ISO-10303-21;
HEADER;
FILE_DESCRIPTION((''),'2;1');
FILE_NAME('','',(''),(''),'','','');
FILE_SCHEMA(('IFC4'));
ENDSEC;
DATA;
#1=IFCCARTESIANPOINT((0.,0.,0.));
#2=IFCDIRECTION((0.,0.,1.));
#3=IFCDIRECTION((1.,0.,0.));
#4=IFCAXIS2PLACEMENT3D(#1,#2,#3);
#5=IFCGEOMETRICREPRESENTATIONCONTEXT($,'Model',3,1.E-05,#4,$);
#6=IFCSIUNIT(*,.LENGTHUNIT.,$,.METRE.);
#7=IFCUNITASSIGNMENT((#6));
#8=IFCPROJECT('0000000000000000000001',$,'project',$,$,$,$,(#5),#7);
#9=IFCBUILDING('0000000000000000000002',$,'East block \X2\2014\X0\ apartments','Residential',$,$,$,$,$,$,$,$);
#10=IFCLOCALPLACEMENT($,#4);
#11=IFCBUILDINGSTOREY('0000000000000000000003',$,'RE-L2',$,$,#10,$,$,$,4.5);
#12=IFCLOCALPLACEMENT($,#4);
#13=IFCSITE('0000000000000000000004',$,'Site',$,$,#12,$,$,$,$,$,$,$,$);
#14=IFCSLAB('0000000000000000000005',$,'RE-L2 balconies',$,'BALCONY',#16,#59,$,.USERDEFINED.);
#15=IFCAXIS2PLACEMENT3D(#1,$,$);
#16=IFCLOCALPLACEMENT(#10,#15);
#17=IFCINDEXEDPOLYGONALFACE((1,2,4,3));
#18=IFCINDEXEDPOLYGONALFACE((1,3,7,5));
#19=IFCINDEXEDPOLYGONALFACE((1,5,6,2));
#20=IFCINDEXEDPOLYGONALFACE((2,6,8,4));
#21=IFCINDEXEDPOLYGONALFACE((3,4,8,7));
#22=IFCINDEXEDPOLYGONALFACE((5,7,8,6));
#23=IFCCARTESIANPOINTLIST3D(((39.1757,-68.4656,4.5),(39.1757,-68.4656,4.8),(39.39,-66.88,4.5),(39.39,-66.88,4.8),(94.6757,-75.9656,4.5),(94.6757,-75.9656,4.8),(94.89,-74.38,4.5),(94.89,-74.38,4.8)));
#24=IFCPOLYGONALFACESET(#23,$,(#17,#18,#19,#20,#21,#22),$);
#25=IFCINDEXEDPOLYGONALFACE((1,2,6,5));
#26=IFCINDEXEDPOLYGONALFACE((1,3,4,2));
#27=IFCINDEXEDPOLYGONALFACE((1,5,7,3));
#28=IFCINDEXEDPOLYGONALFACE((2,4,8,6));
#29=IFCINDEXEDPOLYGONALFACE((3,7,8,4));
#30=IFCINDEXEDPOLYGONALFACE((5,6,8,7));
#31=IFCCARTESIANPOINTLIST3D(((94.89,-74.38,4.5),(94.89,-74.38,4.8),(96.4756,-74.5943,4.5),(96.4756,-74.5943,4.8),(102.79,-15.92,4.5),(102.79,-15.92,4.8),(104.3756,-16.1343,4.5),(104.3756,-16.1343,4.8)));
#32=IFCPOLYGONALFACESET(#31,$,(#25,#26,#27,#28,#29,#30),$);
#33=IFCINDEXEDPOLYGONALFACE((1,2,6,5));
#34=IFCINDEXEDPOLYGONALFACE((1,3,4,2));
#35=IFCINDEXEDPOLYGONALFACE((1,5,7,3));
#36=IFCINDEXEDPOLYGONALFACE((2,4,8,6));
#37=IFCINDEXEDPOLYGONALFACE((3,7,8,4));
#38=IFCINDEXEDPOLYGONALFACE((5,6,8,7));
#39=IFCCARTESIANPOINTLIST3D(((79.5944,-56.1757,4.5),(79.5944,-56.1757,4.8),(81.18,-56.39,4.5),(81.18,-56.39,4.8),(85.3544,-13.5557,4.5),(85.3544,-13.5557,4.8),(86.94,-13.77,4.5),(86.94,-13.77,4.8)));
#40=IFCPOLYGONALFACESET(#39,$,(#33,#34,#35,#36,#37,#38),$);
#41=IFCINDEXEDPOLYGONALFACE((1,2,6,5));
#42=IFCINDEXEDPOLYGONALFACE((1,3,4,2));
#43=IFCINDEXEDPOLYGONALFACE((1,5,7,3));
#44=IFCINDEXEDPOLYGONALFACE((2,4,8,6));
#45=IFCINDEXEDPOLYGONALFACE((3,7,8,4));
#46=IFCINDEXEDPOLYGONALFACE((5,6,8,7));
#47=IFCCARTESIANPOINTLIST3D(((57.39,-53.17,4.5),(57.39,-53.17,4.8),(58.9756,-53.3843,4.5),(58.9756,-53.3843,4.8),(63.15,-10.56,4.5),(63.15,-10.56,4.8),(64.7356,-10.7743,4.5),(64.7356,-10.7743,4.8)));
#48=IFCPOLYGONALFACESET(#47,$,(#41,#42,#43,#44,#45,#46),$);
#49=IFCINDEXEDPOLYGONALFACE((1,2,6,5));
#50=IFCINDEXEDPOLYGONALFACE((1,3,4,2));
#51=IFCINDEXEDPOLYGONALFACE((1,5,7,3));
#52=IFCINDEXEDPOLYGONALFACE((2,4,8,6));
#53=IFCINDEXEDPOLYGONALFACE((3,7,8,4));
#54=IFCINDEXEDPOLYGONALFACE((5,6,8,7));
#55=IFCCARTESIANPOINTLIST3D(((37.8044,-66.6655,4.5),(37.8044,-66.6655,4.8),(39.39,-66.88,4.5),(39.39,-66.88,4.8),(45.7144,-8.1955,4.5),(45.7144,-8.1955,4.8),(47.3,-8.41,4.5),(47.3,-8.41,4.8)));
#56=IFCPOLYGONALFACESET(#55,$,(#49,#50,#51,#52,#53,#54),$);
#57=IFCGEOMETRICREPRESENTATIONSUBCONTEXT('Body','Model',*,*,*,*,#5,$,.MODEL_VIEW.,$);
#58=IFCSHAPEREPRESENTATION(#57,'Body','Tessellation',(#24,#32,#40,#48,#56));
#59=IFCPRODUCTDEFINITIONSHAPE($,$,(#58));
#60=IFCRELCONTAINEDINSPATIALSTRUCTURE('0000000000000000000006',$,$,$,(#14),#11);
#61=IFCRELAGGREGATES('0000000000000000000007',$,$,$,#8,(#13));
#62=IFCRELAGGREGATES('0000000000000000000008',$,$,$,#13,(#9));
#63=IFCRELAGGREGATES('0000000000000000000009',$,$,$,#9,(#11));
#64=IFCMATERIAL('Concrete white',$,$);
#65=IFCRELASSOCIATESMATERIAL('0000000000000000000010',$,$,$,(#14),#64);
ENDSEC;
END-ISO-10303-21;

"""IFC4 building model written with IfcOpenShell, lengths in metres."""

from ifc_helpers import new_model, si_unit, frame, origin_with_axes, place, context, subcontext, project, spatial, polyline, outline, extrude, material, element, save


model = new_model("IFC4")

# Units and contexts
model_context = context("Model", 3, precision=1e-05, world=origin_with_axes())
body_context = subcontext(model_context, "Body", "Model", "MODEL_VIEW")
ifc_project = project(units=[si_unit("LENGTHUNIT", "METRE")], contexts=[model_context])

# Site, building, storey
site_placement = place(None, origin_with_axes())
site = spatial("IfcSite", under=ifc_project, at=site_placement, Name="Site")
building = spatial("IfcBuilding", under=site, Name="East block — apartments", Description="Residential")
storey_placement = place(None, origin_with_axes())
storey = spatial("IfcBuildingStorey", under=building, at=storey_placement, Name="RE-L2", Elevation=4.5)

# Slab
ifc_material_1 = material(Name="Concrete white")
slab_placement = place(storey_placement, origin_with_axes())
element("IfcSlab", 1, at=slab_placement, inside=storey, material=ifc_material_1, Name="RE-L2 balconies", ObjectType="BALCONY", PredefinedType="USERDEFINED", context=body_context, shape_type="SweptSolid", body=[
    extrude(outline(polyline([(39.39, -66.88), (94.89, -74.38), (94.6757, -75.9656), (39.1757, -68.4656), (39.39, -66.88)])), frame((0.0, 0.0, 4.5), z_axis=(0.0, 0.0, 1.0), x_axis=(1.0, 0.0, 0.0)), (0.0, 0.0, 1.0), 0.3),
    extrude(outline(polyline([(94.89, -74.38), (102.79, -15.92), (104.3756, -16.1343), (96.4756, -74.5943), (94.89, -74.38)])), frame((0.0, 0.0, 4.5), z_axis=(0.0, 0.0, 1.0), x_axis=(1.0, 0.0, 0.0)), (0.0, 0.0, 1.0), 0.3),
    extrude(outline(polyline([(86.94, -13.77), (81.18, -56.39), (79.5944, -56.1757), (85.3544, -13.5557), (86.94, -13.77)])), frame((0.0, 0.0, 4.5), z_axis=(0.0, 0.0, 1.0), x_axis=(1.0, 0.0, 0.0)), (0.0, 0.0, 1.0), 0.3),
    extrude(outline(polyline([(57.39, -53.17), (63.15, -10.56), (64.7356, -10.7743), (58.9756, -53.3843), (57.39, -53.17)])), frame((0.0, 0.0, 4.5), z_axis=(0.0, 0.0, 1.0), x_axis=(1.0, 0.0, 0.0)), (0.0, 0.0, 1.0), 0.3),
    extrude(outline(polyline([(47.3, -8.41), (39.39, -66.88), (37.8044, -66.6655), (45.7144, -8.1955), (47.3, -8.41)])), frame((0.0, 0.0, 4.5), z_axis=(0.0, 0.0, 1.0), x_axis=(1.0, 0.0, 0.0)), (0.0, 0.0, 1.0), 0.3),
])

save(model, "model.ifc")
